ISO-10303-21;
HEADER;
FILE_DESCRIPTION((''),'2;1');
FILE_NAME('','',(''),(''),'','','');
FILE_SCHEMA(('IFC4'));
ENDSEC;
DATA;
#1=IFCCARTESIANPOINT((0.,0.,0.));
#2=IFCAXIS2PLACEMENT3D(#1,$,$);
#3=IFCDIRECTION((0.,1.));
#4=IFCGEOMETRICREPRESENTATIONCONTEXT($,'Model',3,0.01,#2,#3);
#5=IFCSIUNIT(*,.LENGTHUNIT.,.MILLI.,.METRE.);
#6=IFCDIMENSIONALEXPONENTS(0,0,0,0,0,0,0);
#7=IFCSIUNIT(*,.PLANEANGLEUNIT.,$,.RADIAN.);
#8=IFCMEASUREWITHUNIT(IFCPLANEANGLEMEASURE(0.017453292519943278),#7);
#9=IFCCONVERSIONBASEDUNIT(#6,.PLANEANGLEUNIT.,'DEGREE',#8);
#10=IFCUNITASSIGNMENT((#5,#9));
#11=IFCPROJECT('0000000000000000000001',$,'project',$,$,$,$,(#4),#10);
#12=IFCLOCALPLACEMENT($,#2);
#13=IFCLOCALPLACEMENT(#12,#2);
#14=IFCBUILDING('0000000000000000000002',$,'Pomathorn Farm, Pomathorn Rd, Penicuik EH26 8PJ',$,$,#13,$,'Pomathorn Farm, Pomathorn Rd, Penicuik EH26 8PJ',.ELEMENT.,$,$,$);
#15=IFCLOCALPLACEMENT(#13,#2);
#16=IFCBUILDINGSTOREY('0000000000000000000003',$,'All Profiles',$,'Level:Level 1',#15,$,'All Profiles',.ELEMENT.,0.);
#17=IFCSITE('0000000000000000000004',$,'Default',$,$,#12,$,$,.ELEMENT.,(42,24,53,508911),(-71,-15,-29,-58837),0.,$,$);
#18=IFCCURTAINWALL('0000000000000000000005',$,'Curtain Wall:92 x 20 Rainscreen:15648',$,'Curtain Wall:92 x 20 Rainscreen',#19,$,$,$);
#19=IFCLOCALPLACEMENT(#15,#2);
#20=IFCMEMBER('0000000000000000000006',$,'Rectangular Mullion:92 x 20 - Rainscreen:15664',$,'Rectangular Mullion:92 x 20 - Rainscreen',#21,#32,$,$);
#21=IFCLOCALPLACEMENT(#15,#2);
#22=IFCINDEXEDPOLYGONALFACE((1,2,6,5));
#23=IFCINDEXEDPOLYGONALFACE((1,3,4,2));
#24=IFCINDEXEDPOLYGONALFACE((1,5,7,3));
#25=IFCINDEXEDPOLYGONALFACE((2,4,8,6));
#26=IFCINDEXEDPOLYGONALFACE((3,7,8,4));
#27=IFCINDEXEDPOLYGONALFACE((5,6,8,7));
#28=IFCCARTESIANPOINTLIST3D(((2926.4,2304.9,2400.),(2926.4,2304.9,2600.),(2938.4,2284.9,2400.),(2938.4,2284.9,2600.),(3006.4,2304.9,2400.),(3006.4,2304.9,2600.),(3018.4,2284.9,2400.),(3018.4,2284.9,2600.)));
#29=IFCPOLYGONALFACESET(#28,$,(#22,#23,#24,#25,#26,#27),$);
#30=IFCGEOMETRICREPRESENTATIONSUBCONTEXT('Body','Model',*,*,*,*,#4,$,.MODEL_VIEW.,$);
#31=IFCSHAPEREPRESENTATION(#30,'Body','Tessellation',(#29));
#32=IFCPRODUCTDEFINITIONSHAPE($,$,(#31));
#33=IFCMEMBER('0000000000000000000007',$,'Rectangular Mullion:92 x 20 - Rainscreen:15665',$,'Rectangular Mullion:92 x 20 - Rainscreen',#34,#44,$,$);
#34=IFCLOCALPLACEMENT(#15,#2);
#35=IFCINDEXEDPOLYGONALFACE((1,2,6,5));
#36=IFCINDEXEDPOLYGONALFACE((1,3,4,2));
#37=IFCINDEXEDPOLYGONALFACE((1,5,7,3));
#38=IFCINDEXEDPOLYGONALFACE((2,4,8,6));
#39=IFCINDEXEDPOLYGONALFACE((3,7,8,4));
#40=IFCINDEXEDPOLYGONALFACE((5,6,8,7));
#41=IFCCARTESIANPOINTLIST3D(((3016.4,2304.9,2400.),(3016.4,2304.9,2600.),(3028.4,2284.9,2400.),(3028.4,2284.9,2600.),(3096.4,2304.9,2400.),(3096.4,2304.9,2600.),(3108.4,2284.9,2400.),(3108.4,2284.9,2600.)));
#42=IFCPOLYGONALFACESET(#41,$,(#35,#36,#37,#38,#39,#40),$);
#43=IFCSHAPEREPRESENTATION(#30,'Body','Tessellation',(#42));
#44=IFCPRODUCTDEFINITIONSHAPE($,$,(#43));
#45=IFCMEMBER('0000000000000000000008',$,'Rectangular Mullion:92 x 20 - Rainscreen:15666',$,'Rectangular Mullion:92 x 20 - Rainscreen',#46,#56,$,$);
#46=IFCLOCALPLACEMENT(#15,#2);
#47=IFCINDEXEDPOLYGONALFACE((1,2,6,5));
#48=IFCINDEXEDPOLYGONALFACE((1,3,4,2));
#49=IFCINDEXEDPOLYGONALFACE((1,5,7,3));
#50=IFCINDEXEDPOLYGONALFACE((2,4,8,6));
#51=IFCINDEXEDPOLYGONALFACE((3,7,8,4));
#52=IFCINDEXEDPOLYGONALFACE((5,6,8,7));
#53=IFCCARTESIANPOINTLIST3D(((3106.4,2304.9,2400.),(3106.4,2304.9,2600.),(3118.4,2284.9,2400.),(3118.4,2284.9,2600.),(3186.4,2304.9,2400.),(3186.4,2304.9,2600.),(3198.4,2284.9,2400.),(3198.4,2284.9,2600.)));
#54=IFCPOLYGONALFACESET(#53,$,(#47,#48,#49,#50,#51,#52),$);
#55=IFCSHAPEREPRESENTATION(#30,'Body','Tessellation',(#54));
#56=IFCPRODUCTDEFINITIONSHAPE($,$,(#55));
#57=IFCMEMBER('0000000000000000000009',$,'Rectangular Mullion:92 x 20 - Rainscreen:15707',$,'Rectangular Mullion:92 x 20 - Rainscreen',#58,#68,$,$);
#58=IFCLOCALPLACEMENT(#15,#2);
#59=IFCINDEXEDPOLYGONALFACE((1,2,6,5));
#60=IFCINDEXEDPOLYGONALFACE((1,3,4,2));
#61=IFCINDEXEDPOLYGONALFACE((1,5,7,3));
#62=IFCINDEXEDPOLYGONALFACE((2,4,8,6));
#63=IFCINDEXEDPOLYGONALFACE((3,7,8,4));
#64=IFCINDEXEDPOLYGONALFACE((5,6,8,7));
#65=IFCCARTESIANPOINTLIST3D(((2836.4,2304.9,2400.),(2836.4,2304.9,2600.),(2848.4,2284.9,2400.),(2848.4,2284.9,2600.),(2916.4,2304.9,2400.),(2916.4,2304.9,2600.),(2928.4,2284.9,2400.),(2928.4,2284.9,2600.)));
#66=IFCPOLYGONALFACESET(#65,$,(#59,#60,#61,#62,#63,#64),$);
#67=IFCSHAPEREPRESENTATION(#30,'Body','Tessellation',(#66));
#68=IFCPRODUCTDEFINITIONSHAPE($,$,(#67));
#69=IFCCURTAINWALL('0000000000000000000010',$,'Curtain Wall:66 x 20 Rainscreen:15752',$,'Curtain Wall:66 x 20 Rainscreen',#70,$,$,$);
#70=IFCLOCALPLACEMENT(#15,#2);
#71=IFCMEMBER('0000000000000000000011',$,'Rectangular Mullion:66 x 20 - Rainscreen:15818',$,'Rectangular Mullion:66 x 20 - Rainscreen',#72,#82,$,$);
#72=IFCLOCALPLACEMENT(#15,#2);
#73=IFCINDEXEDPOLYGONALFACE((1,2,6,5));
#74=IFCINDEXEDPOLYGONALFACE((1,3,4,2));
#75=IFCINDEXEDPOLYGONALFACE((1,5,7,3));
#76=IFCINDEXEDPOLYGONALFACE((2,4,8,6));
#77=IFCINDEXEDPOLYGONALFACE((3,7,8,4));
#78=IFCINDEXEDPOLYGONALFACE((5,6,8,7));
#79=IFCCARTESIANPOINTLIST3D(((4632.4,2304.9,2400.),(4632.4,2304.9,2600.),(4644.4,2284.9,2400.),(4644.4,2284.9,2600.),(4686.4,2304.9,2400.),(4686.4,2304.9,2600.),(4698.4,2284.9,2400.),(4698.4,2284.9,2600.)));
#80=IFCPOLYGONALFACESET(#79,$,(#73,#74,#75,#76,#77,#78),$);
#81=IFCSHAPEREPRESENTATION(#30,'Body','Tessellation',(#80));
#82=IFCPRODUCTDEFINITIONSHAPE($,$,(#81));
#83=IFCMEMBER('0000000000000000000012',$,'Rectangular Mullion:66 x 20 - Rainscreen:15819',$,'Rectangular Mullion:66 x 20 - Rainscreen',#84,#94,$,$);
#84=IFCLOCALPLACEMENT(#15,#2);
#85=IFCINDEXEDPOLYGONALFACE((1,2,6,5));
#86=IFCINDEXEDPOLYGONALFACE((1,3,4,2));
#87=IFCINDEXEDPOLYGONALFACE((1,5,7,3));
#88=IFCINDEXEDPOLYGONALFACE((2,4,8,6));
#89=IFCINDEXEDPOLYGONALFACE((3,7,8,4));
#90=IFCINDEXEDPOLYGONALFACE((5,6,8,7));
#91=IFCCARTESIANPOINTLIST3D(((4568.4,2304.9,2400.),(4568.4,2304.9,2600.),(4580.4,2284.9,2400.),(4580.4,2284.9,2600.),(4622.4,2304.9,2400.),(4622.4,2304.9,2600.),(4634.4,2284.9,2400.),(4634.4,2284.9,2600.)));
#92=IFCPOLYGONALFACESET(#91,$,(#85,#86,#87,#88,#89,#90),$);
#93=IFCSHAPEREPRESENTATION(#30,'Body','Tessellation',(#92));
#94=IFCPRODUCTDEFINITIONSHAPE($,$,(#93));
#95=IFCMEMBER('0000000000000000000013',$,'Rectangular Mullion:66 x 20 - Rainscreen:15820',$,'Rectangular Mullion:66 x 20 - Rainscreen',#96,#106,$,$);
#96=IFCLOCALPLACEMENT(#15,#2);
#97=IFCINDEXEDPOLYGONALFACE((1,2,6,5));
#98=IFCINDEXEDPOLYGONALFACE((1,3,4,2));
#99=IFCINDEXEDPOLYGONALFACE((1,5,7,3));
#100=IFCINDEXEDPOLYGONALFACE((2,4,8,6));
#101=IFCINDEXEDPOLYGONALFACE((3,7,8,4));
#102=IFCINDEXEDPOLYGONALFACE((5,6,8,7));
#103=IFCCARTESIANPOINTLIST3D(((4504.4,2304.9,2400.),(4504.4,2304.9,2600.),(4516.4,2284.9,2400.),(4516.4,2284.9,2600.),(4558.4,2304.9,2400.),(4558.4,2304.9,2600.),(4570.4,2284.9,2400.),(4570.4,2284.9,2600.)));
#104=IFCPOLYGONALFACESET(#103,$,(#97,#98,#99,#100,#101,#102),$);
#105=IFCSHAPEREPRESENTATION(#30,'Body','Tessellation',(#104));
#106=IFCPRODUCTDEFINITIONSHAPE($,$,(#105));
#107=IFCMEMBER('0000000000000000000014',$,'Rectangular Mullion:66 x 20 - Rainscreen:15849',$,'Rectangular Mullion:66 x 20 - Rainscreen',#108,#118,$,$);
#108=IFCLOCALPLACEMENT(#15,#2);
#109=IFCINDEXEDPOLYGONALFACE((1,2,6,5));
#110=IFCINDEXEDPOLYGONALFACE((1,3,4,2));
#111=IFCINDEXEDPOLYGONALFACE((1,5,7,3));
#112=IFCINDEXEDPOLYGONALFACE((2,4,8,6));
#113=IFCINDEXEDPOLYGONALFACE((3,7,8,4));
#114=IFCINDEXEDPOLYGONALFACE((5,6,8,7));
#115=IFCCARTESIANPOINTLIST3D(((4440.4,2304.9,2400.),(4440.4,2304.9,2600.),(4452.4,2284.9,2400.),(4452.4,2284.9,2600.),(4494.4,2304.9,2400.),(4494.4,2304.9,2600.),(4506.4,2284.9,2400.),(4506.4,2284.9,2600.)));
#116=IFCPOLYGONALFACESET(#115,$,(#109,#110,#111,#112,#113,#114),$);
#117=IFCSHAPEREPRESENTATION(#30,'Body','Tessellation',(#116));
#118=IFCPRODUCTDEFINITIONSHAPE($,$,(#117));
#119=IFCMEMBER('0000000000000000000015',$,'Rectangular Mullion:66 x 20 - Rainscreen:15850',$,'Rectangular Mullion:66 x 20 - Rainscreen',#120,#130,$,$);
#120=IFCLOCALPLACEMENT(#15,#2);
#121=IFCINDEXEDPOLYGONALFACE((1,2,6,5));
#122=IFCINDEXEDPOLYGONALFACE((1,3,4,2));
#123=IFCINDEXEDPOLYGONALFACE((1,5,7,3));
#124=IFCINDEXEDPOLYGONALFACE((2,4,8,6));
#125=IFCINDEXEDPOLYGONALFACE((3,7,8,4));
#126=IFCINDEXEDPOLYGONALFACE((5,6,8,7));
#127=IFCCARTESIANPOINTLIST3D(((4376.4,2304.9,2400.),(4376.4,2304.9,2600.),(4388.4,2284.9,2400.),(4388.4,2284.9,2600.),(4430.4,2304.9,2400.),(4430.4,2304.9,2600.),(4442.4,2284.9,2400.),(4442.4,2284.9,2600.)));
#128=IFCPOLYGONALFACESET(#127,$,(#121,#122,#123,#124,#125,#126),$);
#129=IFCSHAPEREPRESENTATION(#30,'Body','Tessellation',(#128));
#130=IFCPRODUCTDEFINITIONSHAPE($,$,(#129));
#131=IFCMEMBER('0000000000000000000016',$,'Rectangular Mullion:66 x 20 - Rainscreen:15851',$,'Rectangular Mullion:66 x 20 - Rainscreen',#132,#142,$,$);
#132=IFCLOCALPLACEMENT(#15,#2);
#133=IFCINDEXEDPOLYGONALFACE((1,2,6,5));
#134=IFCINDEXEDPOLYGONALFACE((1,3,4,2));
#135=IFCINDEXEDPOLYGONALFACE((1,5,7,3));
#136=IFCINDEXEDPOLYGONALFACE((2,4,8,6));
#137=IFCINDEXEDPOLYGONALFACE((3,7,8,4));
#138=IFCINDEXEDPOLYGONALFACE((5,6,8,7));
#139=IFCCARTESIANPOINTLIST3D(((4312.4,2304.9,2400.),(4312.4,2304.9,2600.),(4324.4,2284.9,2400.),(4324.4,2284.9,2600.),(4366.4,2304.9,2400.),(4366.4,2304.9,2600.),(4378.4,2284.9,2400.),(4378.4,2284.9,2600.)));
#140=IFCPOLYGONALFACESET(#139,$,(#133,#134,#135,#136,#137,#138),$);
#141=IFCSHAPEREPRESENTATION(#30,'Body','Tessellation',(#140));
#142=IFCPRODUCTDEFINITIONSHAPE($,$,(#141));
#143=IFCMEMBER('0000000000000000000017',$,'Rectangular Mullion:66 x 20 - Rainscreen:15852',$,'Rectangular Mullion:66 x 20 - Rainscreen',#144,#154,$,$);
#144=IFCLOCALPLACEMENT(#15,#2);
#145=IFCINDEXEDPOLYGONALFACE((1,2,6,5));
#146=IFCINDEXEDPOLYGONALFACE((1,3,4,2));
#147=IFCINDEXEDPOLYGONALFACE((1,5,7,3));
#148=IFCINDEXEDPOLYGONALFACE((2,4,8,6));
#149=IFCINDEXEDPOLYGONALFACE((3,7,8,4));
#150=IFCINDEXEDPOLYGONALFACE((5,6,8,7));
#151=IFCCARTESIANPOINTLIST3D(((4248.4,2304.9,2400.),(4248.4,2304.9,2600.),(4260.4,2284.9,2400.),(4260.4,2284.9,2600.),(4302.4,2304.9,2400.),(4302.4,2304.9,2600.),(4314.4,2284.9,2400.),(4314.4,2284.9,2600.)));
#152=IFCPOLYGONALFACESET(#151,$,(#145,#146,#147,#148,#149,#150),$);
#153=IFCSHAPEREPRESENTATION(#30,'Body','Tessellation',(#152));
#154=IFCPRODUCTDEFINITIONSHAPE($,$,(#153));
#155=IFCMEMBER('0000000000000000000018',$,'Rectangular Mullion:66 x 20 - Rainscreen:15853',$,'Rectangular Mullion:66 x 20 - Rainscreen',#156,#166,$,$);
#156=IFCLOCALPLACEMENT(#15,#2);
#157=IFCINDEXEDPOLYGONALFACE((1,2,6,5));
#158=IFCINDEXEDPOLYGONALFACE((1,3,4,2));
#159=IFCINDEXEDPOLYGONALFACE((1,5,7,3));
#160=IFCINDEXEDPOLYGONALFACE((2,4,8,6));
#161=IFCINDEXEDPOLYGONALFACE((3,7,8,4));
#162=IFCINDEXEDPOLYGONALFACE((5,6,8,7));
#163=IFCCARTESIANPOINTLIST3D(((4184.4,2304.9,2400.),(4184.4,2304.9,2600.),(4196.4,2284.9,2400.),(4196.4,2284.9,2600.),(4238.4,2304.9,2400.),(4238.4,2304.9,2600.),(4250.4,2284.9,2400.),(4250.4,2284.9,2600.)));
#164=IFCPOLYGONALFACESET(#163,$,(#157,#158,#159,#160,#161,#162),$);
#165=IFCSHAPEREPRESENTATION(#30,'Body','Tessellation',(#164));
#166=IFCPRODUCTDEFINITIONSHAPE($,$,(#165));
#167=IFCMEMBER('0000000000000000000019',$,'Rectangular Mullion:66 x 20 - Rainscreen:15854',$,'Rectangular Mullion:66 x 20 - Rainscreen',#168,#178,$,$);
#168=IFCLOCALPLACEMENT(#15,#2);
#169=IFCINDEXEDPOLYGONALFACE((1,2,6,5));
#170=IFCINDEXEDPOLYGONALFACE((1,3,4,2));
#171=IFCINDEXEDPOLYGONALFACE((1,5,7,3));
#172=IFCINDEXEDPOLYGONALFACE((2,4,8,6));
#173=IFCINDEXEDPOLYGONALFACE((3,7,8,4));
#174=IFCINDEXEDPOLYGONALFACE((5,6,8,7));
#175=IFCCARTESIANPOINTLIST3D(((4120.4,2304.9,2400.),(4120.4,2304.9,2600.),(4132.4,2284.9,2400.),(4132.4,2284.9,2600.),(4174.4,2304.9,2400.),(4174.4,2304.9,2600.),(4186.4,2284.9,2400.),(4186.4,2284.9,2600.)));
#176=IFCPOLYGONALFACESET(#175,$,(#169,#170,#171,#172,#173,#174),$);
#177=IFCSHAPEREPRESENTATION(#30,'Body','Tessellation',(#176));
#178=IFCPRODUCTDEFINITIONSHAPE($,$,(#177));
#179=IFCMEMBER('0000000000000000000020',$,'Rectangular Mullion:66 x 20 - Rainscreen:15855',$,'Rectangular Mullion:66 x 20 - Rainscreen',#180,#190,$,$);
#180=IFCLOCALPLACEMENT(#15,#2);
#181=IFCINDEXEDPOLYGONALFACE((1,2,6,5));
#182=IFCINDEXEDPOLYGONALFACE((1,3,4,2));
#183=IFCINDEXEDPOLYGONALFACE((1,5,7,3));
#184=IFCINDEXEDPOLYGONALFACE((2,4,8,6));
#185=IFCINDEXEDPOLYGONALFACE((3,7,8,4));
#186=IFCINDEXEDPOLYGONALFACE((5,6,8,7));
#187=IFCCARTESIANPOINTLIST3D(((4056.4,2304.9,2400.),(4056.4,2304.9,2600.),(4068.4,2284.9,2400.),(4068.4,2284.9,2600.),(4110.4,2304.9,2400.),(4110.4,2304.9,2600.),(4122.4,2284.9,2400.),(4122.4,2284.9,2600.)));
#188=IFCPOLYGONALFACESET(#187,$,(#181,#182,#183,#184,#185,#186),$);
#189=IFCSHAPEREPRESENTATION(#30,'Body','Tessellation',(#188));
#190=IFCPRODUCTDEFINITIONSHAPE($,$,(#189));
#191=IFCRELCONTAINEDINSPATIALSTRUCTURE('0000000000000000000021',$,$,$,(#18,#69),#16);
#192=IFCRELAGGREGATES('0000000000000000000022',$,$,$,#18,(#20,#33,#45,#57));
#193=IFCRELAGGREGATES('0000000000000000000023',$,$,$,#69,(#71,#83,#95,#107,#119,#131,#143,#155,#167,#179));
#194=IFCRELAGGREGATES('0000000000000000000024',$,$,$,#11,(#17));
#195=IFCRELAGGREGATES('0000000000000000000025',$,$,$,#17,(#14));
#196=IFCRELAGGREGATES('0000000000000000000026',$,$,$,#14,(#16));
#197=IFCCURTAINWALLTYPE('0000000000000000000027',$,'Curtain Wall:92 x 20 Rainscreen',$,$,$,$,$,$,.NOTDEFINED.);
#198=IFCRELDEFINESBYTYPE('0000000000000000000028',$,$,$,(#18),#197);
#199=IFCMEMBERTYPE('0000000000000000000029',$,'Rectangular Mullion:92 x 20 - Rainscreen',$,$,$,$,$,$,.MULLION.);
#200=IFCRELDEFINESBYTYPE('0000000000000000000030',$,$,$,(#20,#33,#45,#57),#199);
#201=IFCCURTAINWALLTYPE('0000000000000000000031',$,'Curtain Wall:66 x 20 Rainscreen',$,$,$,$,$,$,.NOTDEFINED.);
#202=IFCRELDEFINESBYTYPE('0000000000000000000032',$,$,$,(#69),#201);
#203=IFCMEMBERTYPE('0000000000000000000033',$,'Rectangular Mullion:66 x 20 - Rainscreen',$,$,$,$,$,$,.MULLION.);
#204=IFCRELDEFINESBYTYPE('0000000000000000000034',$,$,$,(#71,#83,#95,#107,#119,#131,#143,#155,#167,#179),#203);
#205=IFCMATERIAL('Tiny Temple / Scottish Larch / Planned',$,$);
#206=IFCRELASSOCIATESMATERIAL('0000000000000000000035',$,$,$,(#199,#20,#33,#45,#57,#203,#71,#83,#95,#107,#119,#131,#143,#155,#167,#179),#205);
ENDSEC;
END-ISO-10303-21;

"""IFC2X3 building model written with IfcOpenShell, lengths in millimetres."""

from ifc_helpers import new_model, entity, si_unit, converted_unit, direction, frame, origin, place, context, subcontext, project, spatial, polyline, outline, extrude, source, transform, mapped, material, type_object, type_shapes, element, aggregate, save


model = new_model("IFC2X3")

# Units and contexts
model_context = context("Model", 3, precision=0.01, world=origin(), true_north=direction((0.0, 1.0)))
body_context = subcontext(model_context, "Body", "Model", "MODEL_VIEW")
ifc_project = project(units=[si_unit("LENGTHUNIT", "METRE", prefix="MILLI"), converted_unit("PLANEANGLEUNIT", "DEGREE", entity("IfcPlaneAngleMeasure", 0.017453292519943278), si_unit("PLANEANGLEUNIT", "RADIAN"), dimensions=[0, 0, 0, 0, 0, 0, 0])], contexts=[model_context])

# Site, building, storey
site_placement = place(None, origin())
site = spatial("IfcSite", under=ifc_project, at=site_placement, Name="Default", CompositionType="ELEMENT", RefLatitude=(42, 24, 53, 508911), RefLongitude=(-71, -15, -29, -58837), RefElevation=0.0)
building_placement = place(site_placement, origin())
building = spatial("IfcBuilding", under=site, at=building_placement, Name="Pomathorn Farm, Pomathorn Rd, Penicuik EH26 8PJ", LongName="Pomathorn Farm, Pomathorn Rd, Penicuik EH26 8PJ", CompositionType="ELEMENT")
storey_placement = place(building_placement, origin())
storey = spatial("IfcBuildingStorey", under=building, at=storey_placement, Name="All Profiles", ObjectType="Level:Level 1", LongName="All Profiles", CompositionType="ELEMENT", Elevation=0.0)

# Curtain walls, members
curtain_wall_type_1 = type_object("IfcCurtainWallType", Name="Curtain Wall:92 x 20 Rainscreen", PredefinedType="NOTDEFINED")
curtain_wall_1_placement = place(storey_placement, origin())
curtain_wall_1 = element("IfcCurtainWall", 1, at=curtain_wall_1_placement, inside=storey, type_object=curtain_wall_type_1, Name="Curtain Wall:92 x 20 Rainscreen:15648", ObjectType="Curtain Wall:92 x 20 Rainscreen")
ifc_material = material(Name="Tiny Temple / Scottish Larch / Planned")
member_type_1 = type_object("IfcMemberType", Name="Rectangular Mullion:92 x 20 - Rainscreen", PredefinedType="MULLION", material=ifc_material)
shared_shape_1 = source(origin(), body_context, "Body", "SweptSolid", [
    extrude(outline(polyline([(8.9, -34.3), (32.2, -34.3), (-8.9, 34.3), (-32.2, 34.3), (8.9, -34.3)])), frame((-46.0, -10.0, -200.0), z_axis=(0.0, 0.0, 1.0), x_axis=(0.514496, 0.857493, 0.0)), (0.0, 0.0, 1.0), 200.0),
])
type_shapes(member_type_1, [shared_shape_1])
member_1_placement = place(curtain_wall_1_placement, frame((3018.4, 2284.9, 2400.0), z_axis=(0.0, 0.0, -1.0), x_axis=(1.0, 0.0, 0.0)))
member_1 = element("IfcMember", 2, at=member_1_placement, type_object=member_type_1, material=ifc_material, Name="Rectangular Mullion:92 x 20 - Rainscreen:15664", ObjectType="Rectangular Mullion:92 x 20 - Rainscreen", context=body_context, shape_type="MappedRepresentation", body=[
    mapped(shared_shape_1, transform((0.0, 0.0, 0.0), scale=1.0)),
])
member_2_placement = place(curtain_wall_1_placement, frame((3108.4, 2284.9, 2400.0), z_axis=(0.0, 0.0, -1.0), x_axis=(1.0, 0.0, 0.0)))
member_2 = element("IfcMember", 3, at=member_2_placement, type_object=member_type_1, material=ifc_material, Name="Rectangular Mullion:92 x 20 - Rainscreen:15665", ObjectType="Rectangular Mullion:92 x 20 - Rainscreen", context=body_context, shape_type="MappedRepresentation", body=[
    mapped(shared_shape_1, transform((0.0, 0.0, 0.0), scale=1.0)),
])
member_3_placement = place(curtain_wall_1_placement, frame((3198.4, 2284.9, 2400.0), z_axis=(0.0, 0.0, -1.0), x_axis=(1.0, 0.0, 0.0)))
member_3 = element("IfcMember", 4, at=member_3_placement, type_object=member_type_1, material=ifc_material, Name="Rectangular Mullion:92 x 20 - Rainscreen:15666", ObjectType="Rectangular Mullion:92 x 20 - Rainscreen", context=body_context, shape_type="MappedRepresentation", body=[
    mapped(shared_shape_1, transform((0.0, 0.0, 0.0), scale=1.0)),
])
member_4_placement = place(curtain_wall_1_placement, frame((2928.4, 2284.9, 2400.0), z_axis=(0.0, 0.0, -1.0), x_axis=(1.0, 0.0, 0.0)))
member_4 = element("IfcMember", 5, at=member_4_placement, type_object=member_type_1, material=ifc_material, Name="Rectangular Mullion:92 x 20 - Rainscreen:15707", ObjectType="Rectangular Mullion:92 x 20 - Rainscreen", context=body_context, shape_type="MappedRepresentation", body=[
    mapped(shared_shape_1, transform((0.0, 0.0, 0.0), scale=1.0)),
])
aggregate(curtain_wall_1, [member_1, member_2, member_3, member_4])
curtain_wall_type_2 = type_object("IfcCurtainWallType", Name="Curtain Wall:66 x 20 Rainscreen", PredefinedType="NOTDEFINED")
curtain_wall_2_placement = place(storey_placement, origin())
curtain_wall_2 = element("IfcCurtainWall", 6, at=curtain_wall_2_placement, inside=storey, type_object=curtain_wall_type_2, Name="Curtain Wall:66 x 20 Rainscreen:15752", ObjectType="Curtain Wall:66 x 20 Rainscreen")
member_type_2 = type_object("IfcMemberType", Name="Rectangular Mullion:66 x 20 - Rainscreen", PredefinedType="MULLION", material=ifc_material)
shared_shape_2 = source(origin(), body_context, "Body", "SweptSolid", [
    extrude(outline(polyline([(2.2, -23.2), (25.6, -23.2), (-2.2, 23.2), (-25.6, 23.2), (2.2, -23.2)])), frame((-33.0, -10.0, -200.0), z_axis=(0.0, 0.0, 1.0), x_axis=(0.514496, 0.857493, 0.0)), (0.0, 0.0, 1.0), 200.0),
])
type_shapes(member_type_2, [shared_shape_2])
member_5_placement = place(curtain_wall_2_placement, frame((4698.4, 2284.9, 2400.0), z_axis=(0.0, 0.0, -1.0), x_axis=(1.0, 0.0, 0.0)))
member_5 = element("IfcMember", 7, at=member_5_placement, type_object=member_type_2, material=ifc_material, Name="Rectangular Mullion:66 x 20 - Rainscreen:15818", ObjectType="Rectangular Mullion:66 x 20 - Rainscreen", context=body_context, shape_type="MappedRepresentation", body=[
    mapped(shared_shape_2, transform((0.0, 0.0, 0.0), scale=1.0)),
])
member_6_placement = place(curtain_wall_2_placement, frame((4634.4, 2284.9, 2400.0), z_axis=(0.0, 0.0, -1.0), x_axis=(1.0, 0.0, 0.0)))
member_6 = element("IfcMember", 8, at=member_6_placement, type_object=member_type_2, material=ifc_material, Name="Rectangular Mullion:66 x 20 - Rainscreen:15819", ObjectType="Rectangular Mullion:66 x 20 - Rainscreen", context=body_context, shape_type="MappedRepresentation", body=[
    mapped(shared_shape_2, transform((0.0, 0.0, 0.0), scale=1.0)),
])
member_7_placement = place(curtain_wall_2_placement, frame((4570.4, 2284.9, 2400.0), z_axis=(0.0, 0.0, -1.0), x_axis=(1.0, 0.0, 0.0)))
member_7 = element("IfcMember", 9, at=member_7_placement, type_object=member_type_2, material=ifc_material, Name="Rectangular Mullion:66 x 20 - Rainscreen:15820", ObjectType="Rectangular Mullion:66 x 20 - Rainscreen", context=body_context, shape_type="MappedRepresentation", body=[
    mapped(shared_shape_2, transform((0.0, 0.0, 0.0), scale=1.0)),
])
member_8_placement = place(curtain_wall_2_placement, frame((4506.4, 2284.9, 2400.0), z_axis=(0.0, 0.0, -1.0), x_axis=(1.0, 0.0, 0.0)))
member_8 = element("IfcMember", 10, at=member_8_placement, type_object=member_type_2, material=ifc_material, Name="Rectangular Mullion:66 x 20 - Rainscreen:15849", ObjectType="Rectangular Mullion:66 x 20 - Rainscreen", context=body_context, shape_type="MappedRepresentation", body=[
    mapped(shared_shape_2, transform((0.0, 0.0, 0.0), scale=1.0)),
])
member_9_placement = place(curtain_wall_2_placement, frame((4442.4, 2284.9, 2400.0), z_axis=(0.0, 0.0, -1.0), x_axis=(1.0, 0.0, 0.0)))
member_9 = element("IfcMember", 11, at=member_9_placement, type_object=member_type_2, material=ifc_material, Name="Rectangular Mullion:66 x 20 - Rainscreen:15850", ObjectType="Rectangular Mullion:66 x 20 - Rainscreen", context=body_context, shape_type="MappedRepresentation", body=[
    mapped(shared_shape_2, transform((0.0, 0.0, 0.0), scale=1.0)),
])
member_10_placement = place(curtain_wall_2_placement, frame((4378.4, 2284.9, 2400.0), z_axis=(0.0, 0.0, -1.0), x_axis=(1.0, 0.0, 0.0)))
member_10 = element("IfcMember", 12, at=member_10_placement, type_object=member_type_2, material=ifc_material, Name="Rectangular Mullion:66 x 20 - Rainscreen:15851", ObjectType="Rectangular Mullion:66 x 20 - Rainscreen", context=body_context, shape_type="MappedRepresentation", body=[
    mapped(shared_shape_2, transform((0.0, 0.0, 0.0), scale=1.0)),
])
member_11_placement = place(curtain_wall_2_placement, frame((4314.4, 2284.9, 2400.0), z_axis=(0.0, 0.0, -1.0), x_axis=(1.0, 0.0, 0.0)))
member_11 = element("IfcMember", 13, at=member_11_placement, type_object=member_type_2, material=ifc_material, Name="Rectangular Mullion:66 x 20 - Rainscreen:15852", ObjectType="Rectangular Mullion:66 x 20 - Rainscreen", context=body_context, shape_type="MappedRepresentation", body=[
    mapped(shared_shape_2, transform((0.0, 0.0, 0.0), scale=1.0)),
])
member_12_placement = place(curtain_wall_2_placement, frame((4250.4, 2284.9, 2400.0), z_axis=(0.0, 0.0, -1.0), x_axis=(1.0, 0.0, 0.0)))
member_12 = element("IfcMember", 14, at=member_12_placement, type_object=member_type_2, material=ifc_material, Name="Rectangular Mullion:66 x 20 - Rainscreen:15853", ObjectType="Rectangular Mullion:66 x 20 - Rainscreen", context=body_context, shape_type="MappedRepresentation", body=[
    mapped(shared_shape_2, transform((0.0, 0.0, 0.0), scale=1.0)),
])
member_13_placement = place(curtain_wall_2_placement, frame((4186.4, 2284.9, 2400.0), z_axis=(0.0, 0.0, -1.0), x_axis=(1.0, 0.0, 0.0)))
member_13 = element("IfcMember", 15, at=member_13_placement, type_object=member_type_2, material=ifc_material, Name="Rectangular Mullion:66 x 20 - Rainscreen:15854", ObjectType="Rectangular Mullion:66 x 20 - Rainscreen", context=body_context, shape_type="MappedRepresentation", body=[
    mapped(shared_shape_2, transform((0.0, 0.0, 0.0), scale=1.0)),
])
member_14_placement = place(curtain_wall_2_placement, frame((4122.4, 2284.9, 2400.0), z_axis=(0.0, 0.0, -1.0), x_axis=(1.0, 0.0, 0.0)))
member_14 = element("IfcMember", 16, at=member_14_placement, type_object=member_type_2, material=ifc_material, Name="Rectangular Mullion:66 x 20 - Rainscreen:15855", ObjectType="Rectangular Mullion:66 x 20 - Rainscreen", context=body_context, shape_type="MappedRepresentation", body=[
    mapped(shared_shape_2, transform((0.0, 0.0, 0.0), scale=1.0)),
])
aggregate(curtain_wall_2, [member_5, member_6, member_7, member_8, member_9, member_10, member_11, member_12, member_13, member_14])

save(model, "model.ifc")
